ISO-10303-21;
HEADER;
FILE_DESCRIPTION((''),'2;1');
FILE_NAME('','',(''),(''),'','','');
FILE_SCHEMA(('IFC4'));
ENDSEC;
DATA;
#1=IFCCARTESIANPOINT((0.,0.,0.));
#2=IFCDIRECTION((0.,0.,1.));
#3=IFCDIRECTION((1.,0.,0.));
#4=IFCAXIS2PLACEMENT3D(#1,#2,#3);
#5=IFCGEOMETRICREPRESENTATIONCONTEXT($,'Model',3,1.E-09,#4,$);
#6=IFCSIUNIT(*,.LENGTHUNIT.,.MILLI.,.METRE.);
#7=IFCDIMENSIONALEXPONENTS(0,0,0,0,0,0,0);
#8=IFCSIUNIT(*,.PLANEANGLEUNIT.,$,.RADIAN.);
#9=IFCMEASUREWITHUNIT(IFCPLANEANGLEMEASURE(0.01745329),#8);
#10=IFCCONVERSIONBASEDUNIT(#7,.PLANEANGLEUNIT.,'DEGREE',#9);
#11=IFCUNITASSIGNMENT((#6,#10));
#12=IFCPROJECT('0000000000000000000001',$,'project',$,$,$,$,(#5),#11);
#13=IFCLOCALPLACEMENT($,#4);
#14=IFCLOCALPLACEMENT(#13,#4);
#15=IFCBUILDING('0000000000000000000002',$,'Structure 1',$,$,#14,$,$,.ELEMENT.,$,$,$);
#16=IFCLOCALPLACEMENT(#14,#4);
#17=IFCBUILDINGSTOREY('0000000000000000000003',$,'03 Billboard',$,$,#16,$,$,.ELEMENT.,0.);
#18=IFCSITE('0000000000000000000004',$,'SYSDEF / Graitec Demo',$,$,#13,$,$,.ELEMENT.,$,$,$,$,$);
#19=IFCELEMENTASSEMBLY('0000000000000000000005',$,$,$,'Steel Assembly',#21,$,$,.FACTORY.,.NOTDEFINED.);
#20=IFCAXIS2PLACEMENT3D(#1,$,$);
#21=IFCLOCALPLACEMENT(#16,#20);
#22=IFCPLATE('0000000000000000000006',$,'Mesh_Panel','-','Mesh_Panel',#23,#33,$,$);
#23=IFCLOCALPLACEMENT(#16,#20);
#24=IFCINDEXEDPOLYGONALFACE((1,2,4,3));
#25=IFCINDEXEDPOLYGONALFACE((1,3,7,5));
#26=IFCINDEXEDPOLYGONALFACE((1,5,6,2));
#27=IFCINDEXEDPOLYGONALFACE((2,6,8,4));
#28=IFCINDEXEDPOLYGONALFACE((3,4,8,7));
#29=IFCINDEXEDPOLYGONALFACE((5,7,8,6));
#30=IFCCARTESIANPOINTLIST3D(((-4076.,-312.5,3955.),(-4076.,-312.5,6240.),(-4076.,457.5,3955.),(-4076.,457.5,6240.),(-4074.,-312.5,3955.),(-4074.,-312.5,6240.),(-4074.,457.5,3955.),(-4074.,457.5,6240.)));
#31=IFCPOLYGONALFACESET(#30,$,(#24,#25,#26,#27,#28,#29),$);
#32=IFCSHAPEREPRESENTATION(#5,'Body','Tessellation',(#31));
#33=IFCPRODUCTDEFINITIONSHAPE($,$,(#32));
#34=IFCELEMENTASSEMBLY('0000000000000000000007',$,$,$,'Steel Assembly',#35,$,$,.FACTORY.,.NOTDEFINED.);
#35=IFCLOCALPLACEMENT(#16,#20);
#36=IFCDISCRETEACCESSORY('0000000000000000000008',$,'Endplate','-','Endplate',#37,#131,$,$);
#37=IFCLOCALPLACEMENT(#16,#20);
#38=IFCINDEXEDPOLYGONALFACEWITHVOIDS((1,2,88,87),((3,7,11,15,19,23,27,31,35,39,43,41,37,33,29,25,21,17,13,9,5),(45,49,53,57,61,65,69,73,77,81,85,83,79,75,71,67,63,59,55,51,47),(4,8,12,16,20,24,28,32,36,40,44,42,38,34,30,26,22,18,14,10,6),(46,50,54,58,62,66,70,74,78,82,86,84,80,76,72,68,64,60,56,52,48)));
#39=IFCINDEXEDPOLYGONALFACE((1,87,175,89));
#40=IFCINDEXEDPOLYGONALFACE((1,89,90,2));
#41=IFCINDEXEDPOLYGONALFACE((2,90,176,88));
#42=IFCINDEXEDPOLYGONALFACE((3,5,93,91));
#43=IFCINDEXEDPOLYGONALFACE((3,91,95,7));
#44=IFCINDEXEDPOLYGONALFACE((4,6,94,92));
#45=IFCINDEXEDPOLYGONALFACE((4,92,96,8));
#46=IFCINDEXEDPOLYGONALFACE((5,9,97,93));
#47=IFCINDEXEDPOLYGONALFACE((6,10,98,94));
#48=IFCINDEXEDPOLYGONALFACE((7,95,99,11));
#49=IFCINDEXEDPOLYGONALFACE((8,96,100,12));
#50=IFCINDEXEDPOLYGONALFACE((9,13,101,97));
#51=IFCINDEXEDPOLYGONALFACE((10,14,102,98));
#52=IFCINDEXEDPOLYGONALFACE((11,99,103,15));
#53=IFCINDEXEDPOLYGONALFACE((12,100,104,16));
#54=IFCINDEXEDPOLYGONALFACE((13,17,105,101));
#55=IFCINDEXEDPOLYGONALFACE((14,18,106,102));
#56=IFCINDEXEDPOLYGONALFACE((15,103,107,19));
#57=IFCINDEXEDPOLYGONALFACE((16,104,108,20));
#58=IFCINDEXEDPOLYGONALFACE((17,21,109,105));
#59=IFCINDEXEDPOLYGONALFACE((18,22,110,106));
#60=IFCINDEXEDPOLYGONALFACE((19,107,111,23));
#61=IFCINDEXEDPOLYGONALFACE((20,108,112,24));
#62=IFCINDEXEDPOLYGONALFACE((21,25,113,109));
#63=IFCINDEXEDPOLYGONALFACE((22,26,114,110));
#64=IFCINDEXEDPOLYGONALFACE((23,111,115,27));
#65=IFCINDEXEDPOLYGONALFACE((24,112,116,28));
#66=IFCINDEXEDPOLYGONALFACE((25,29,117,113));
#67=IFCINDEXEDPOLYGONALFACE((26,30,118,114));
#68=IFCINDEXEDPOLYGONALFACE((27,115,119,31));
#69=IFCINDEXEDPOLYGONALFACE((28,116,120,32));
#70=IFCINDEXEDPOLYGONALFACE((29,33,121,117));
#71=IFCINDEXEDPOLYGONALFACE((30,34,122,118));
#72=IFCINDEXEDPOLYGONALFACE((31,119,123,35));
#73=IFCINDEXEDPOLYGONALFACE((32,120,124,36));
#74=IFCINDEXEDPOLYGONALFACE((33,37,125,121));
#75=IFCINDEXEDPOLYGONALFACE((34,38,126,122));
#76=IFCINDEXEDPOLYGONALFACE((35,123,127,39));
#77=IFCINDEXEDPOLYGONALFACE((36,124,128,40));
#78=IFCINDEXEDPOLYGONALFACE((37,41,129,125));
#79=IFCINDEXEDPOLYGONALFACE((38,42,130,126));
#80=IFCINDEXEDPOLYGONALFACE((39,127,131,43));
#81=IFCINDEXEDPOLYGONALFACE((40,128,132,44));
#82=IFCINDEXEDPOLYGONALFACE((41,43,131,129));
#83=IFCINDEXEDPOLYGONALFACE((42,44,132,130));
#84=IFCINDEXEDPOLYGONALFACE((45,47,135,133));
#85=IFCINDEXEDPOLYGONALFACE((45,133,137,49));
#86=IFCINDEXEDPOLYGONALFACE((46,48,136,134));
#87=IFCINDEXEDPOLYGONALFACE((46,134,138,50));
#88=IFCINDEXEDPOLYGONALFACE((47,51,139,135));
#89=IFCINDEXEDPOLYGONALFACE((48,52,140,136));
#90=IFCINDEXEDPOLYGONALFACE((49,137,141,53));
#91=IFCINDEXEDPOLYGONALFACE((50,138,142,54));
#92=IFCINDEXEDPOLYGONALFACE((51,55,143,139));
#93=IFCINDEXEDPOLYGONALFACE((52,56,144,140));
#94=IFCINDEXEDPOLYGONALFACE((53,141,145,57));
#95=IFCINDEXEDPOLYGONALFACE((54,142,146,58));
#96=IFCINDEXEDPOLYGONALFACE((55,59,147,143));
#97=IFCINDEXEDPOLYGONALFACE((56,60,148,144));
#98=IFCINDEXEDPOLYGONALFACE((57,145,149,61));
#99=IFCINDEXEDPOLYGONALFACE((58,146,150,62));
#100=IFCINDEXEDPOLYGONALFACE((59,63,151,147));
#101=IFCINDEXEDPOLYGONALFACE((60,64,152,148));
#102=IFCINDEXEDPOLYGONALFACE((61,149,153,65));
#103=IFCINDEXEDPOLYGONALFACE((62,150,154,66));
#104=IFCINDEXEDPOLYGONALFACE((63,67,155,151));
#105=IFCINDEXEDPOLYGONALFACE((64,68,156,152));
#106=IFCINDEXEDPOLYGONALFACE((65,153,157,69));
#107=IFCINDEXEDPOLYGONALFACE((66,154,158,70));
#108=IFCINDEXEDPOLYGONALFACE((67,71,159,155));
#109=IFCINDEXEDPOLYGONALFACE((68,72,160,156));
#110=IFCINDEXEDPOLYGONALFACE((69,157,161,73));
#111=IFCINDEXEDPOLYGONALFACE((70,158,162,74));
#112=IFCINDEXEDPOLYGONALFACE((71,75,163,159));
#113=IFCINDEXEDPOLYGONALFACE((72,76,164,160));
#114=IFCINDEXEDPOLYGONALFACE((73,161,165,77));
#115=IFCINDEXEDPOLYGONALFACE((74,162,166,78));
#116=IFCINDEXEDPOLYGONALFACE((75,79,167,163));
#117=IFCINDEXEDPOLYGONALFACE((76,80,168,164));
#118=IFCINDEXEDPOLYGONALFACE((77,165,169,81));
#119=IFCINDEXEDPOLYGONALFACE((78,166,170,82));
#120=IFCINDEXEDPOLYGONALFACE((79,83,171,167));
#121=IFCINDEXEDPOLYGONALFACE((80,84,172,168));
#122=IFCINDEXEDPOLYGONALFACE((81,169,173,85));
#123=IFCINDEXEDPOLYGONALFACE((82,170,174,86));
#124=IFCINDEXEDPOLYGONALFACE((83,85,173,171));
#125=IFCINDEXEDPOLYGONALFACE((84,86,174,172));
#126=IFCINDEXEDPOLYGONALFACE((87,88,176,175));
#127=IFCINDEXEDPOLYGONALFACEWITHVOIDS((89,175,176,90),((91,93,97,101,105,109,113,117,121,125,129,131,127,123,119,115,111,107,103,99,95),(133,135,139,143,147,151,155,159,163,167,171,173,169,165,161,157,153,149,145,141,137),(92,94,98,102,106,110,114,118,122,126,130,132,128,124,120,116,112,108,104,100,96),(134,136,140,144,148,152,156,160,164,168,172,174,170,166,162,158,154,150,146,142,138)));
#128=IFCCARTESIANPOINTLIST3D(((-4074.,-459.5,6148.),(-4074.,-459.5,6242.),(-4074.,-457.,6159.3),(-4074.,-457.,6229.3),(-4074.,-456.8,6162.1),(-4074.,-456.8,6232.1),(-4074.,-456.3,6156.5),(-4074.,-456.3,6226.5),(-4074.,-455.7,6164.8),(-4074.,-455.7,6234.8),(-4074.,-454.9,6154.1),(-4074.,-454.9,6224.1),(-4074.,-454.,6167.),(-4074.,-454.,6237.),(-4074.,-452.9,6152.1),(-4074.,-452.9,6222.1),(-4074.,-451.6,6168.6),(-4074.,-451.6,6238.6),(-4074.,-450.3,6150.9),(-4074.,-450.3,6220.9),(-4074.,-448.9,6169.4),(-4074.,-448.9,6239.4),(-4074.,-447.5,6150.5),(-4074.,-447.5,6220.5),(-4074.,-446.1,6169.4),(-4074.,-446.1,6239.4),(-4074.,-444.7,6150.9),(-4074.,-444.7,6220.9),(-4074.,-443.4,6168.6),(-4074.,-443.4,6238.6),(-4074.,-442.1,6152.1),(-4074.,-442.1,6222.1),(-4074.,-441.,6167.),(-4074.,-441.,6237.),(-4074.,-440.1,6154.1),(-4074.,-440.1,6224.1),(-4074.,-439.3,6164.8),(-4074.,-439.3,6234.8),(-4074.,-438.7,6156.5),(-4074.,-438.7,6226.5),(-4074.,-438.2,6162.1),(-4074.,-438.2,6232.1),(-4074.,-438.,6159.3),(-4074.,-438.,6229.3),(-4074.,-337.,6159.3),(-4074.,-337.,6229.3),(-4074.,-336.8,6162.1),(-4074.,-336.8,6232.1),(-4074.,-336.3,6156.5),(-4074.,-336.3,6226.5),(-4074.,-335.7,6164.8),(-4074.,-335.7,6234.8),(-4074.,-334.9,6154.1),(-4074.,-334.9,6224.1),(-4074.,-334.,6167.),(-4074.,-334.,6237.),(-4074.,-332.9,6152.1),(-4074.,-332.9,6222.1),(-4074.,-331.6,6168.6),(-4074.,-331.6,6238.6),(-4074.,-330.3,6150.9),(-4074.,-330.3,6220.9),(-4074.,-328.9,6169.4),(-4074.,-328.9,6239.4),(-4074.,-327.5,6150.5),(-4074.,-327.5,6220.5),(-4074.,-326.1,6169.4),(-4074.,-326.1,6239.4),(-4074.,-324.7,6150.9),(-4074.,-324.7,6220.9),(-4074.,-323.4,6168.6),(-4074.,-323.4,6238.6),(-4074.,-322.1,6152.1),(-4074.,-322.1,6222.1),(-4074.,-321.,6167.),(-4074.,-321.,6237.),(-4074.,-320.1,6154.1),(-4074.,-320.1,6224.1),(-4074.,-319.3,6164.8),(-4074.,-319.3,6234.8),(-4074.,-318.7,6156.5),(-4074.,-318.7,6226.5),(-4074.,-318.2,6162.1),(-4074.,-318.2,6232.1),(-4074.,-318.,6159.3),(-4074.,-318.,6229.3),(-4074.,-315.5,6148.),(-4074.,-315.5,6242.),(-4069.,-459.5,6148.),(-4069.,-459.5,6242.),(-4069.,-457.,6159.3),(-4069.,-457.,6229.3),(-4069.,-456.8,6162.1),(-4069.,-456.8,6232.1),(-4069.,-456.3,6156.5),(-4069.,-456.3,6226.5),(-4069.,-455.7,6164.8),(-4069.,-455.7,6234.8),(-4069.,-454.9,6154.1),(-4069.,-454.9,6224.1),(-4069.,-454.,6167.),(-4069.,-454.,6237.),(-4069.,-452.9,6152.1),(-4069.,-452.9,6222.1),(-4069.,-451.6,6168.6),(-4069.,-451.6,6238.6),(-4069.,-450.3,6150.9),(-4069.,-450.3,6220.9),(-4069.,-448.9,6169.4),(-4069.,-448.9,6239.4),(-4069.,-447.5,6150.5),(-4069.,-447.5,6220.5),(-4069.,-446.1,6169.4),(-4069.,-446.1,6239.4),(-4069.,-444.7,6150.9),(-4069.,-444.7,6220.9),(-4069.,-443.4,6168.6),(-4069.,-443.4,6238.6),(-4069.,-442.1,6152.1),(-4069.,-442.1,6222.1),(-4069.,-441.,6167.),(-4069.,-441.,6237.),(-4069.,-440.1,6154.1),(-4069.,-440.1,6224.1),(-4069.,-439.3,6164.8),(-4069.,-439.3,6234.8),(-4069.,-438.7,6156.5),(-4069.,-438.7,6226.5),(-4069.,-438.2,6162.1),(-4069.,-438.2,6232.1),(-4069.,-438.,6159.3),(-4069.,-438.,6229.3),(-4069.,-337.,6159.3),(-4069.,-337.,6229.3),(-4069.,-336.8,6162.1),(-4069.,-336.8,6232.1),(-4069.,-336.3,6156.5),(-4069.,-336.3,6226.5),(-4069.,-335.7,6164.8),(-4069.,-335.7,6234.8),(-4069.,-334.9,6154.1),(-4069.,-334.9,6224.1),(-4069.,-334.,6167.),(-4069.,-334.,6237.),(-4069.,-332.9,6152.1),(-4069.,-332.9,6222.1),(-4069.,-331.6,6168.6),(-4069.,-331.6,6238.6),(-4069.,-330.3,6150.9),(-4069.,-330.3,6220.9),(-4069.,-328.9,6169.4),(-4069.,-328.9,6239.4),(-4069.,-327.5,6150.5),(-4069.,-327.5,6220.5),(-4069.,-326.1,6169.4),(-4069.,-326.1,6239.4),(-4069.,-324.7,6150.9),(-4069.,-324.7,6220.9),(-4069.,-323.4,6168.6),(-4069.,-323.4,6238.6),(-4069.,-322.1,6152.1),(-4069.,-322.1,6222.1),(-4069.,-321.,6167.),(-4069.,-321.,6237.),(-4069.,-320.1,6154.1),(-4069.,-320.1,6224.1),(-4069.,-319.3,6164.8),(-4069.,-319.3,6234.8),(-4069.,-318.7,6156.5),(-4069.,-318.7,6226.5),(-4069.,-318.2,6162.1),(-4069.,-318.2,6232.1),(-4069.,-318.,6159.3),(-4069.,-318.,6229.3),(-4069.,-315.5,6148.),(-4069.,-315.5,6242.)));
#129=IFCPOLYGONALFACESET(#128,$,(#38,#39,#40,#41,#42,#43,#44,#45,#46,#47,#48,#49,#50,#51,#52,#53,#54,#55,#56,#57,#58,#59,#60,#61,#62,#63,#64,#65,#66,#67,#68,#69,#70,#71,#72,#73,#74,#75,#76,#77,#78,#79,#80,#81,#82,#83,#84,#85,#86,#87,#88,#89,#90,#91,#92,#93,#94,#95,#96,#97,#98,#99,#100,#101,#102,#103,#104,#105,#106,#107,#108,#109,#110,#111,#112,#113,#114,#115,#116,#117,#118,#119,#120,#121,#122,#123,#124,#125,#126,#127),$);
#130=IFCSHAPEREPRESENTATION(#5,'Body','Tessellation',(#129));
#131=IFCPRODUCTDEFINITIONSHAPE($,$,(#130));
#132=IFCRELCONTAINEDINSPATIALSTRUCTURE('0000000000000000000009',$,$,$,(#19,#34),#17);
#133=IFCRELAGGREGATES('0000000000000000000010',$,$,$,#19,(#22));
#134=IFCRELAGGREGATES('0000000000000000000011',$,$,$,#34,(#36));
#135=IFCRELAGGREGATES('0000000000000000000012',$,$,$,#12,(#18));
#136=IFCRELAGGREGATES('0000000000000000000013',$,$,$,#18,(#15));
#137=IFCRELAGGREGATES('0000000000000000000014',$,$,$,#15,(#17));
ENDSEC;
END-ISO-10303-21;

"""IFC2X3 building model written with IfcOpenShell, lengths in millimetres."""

from ifc_helpers import new_model, entity, si_unit, converted_unit, frame, frame_2d, origin, origin_with_axes, place, context, project, spatial, polyline, circle, outline, extrude, element, aggregate, save


model = new_model("IFC2X3")

# Units and contexts
model_context = context("Model", 3, precision=1e-09, world=origin_with_axes())
ifc_project = project(units=[si_unit("LENGTHUNIT", "METRE", prefix="MILLI"), converted_unit("PLANEANGLEUNIT", "DEGREE", entity("IfcPlaneAngleMeasure", 0.01745329), si_unit("PLANEANGLEUNIT", "RADIAN"), dimensions=[0, 0, 0, 0, 0, 0, 0])], contexts=[model_context])

# Site, building, storey
site_placement = place(None, origin_with_axes())
site = spatial("IfcSite", under=ifc_project, at=site_placement, Name="SYSDEF / Graitec Demo", CompositionType="ELEMENT")
building_placement = place(site_placement, origin_with_axes())
building = spatial("IfcBuilding", under=site, at=building_placement, Name="Structure 1", CompositionType="ELEMENT")
storey_placement = place(building_placement, origin_with_axes())
storey = spatial("IfcBuildingStorey", under=building, at=storey_placement, Name="03 Billboard", CompositionType="ELEMENT", Elevation=0.0)

# Element assembly, plate
assembly_1_placement = place(None, frame((-4076.0, 72.5, 5097.5), z_axis=(-1.0, 0.0, 0.000006), x_axis=(0.0, 1.0, 0.000001)))
assembly_1 = element("IfcElementAssembly", 1, at=assembly_1_placement, inside=storey, ObjectType="Steel Assembly", AssemblyPlace="FACTORY", PredefinedType="NOTDEFINED")
plate_placement = place(assembly_1_placement, origin_with_axes())
plate = element("IfcPlate", 2, at=plate_placement, Name="Mesh_Panel", Description="-", ObjectType="Mesh_Panel", context=model_context, shape_type="SweptSolid", body=[
    extrude(outline(polyline([(-385.0, -1142.5), (385.0, -1142.5), (385.0, 1142.5), (-385.0, 1142.5), (-385.0, -1142.5)])), origin_with_axes(), (0.0, 0.0, -1.0), 2.0),
])
aggregate(assembly_1, [plate])

# Element assembly, discrete accessory, openings
assembly_2_placement = place(None, frame((-4239.1, -387.5, 4000.0), z_axis=(-1.0, 0.0, 0.0), x_axis=(0.0, 0.0, 1.0)))
assembly_2 = element("IfcElementAssembly", 3, at=assembly_2_placement, inside=storey, ObjectType="Steel Assembly", AssemblyPlace="FACTORY", PredefinedType="NOTDEFINED")
discrete_accessory_1_placement = place(assembly_2_placement, frame((2242.0, 72.0, -170.1), z_axis=(0.0, 0.0, 1.0), x_axis=(-1.0, 0.0, 0.0)))
discrete_accessory_1 = element("IfcDiscreteAccessory", 4, at=discrete_accessory_1_placement, Name="Endplate", Description="-", ObjectType="Endplate", context=model_context, shape_type="SweptSolid", body=[
    extrude(outline(polyline([(0.0, 0.0), (94.0, 0.0), (94.0, 144.0), (0.0, 144.0), (0.0, 0.0)])), origin_with_axes(), (0.0, 0.0, 1.0), 5.0),
])
opening_1_placement = place(discrete_accessory_1_placement, frame((47.0, 72.0, 5.5), z_axis=(0.0, 0.0, -1.0), x_axis=(1.0, 0.0, 0.0)))
element("IfcOpeningElement", 5, at=opening_1_placement, cuts=discrete_accessory_1, ObjectType="Opening", context=model_context, shape_type="SweptSolid", body=[
    extrude(circle(Radius=9.5, at=frame_2d((35.0, 60.0), x_axis=(1.0, 0.0))), origin(), (0.0, 0.0, 1.0), 6.0),
])
opening_2_placement = place(discrete_accessory_1_placement, frame((47.0, 72.0, 5.5), z_axis=(0.0, 0.0, -1.0), x_axis=(1.0, 0.0, 0.0)))
element("IfcOpeningElement", 6, at=opening_2_placement, cuts=discrete_accessory_1, ObjectType="Opening", context=model_context, shape_type="SweptSolid", body=[
    extrude(circle(Radius=9.5, at=frame_2d((-35.0, 60.0), x_axis=(1.0, 0.0))), origin(), (0.0, 0.0, 1.0), 6.0),
])
opening_3_placement = place(discrete_accessory_1_placement, frame((47.0, 72.0, 5.5), z_axis=(0.0, 0.0, -1.0), x_axis=(1.0, 0.0, 0.0)))
element("IfcOpeningElement", 7, at=opening_3_placement, cuts=discrete_accessory_1, ObjectType="Opening", context=model_context, shape_type="SweptSolid", body=[
    extrude(circle(Radius=9.5, at=frame_2d((35.0, -60.0), x_axis=(1.0, 0.0))), origin(), (0.0, 0.0, 1.0), 6.0),
])
opening_4_placement = place(discrete_accessory_1_placement, frame((47.0, 72.0, 5.5), z_axis=(0.0, 0.0, -1.0), x_axis=(1.0, 0.0, 0.0)))
element("IfcOpeningElement", 8, at=opening_4_placement, cuts=discrete_accessory_1, ObjectType="Opening", context=model_context, shape_type="SweptSolid", body=[
    extrude(circle(Radius=9.5, at=frame_2d((-35.0, -60.0), x_axis=(1.0, 0.0))), origin(), (0.0, 0.0, 1.0), 6.0),
])
aggregate(assembly_2, [discrete_accessory_1])

save(model, "model.ifc")
